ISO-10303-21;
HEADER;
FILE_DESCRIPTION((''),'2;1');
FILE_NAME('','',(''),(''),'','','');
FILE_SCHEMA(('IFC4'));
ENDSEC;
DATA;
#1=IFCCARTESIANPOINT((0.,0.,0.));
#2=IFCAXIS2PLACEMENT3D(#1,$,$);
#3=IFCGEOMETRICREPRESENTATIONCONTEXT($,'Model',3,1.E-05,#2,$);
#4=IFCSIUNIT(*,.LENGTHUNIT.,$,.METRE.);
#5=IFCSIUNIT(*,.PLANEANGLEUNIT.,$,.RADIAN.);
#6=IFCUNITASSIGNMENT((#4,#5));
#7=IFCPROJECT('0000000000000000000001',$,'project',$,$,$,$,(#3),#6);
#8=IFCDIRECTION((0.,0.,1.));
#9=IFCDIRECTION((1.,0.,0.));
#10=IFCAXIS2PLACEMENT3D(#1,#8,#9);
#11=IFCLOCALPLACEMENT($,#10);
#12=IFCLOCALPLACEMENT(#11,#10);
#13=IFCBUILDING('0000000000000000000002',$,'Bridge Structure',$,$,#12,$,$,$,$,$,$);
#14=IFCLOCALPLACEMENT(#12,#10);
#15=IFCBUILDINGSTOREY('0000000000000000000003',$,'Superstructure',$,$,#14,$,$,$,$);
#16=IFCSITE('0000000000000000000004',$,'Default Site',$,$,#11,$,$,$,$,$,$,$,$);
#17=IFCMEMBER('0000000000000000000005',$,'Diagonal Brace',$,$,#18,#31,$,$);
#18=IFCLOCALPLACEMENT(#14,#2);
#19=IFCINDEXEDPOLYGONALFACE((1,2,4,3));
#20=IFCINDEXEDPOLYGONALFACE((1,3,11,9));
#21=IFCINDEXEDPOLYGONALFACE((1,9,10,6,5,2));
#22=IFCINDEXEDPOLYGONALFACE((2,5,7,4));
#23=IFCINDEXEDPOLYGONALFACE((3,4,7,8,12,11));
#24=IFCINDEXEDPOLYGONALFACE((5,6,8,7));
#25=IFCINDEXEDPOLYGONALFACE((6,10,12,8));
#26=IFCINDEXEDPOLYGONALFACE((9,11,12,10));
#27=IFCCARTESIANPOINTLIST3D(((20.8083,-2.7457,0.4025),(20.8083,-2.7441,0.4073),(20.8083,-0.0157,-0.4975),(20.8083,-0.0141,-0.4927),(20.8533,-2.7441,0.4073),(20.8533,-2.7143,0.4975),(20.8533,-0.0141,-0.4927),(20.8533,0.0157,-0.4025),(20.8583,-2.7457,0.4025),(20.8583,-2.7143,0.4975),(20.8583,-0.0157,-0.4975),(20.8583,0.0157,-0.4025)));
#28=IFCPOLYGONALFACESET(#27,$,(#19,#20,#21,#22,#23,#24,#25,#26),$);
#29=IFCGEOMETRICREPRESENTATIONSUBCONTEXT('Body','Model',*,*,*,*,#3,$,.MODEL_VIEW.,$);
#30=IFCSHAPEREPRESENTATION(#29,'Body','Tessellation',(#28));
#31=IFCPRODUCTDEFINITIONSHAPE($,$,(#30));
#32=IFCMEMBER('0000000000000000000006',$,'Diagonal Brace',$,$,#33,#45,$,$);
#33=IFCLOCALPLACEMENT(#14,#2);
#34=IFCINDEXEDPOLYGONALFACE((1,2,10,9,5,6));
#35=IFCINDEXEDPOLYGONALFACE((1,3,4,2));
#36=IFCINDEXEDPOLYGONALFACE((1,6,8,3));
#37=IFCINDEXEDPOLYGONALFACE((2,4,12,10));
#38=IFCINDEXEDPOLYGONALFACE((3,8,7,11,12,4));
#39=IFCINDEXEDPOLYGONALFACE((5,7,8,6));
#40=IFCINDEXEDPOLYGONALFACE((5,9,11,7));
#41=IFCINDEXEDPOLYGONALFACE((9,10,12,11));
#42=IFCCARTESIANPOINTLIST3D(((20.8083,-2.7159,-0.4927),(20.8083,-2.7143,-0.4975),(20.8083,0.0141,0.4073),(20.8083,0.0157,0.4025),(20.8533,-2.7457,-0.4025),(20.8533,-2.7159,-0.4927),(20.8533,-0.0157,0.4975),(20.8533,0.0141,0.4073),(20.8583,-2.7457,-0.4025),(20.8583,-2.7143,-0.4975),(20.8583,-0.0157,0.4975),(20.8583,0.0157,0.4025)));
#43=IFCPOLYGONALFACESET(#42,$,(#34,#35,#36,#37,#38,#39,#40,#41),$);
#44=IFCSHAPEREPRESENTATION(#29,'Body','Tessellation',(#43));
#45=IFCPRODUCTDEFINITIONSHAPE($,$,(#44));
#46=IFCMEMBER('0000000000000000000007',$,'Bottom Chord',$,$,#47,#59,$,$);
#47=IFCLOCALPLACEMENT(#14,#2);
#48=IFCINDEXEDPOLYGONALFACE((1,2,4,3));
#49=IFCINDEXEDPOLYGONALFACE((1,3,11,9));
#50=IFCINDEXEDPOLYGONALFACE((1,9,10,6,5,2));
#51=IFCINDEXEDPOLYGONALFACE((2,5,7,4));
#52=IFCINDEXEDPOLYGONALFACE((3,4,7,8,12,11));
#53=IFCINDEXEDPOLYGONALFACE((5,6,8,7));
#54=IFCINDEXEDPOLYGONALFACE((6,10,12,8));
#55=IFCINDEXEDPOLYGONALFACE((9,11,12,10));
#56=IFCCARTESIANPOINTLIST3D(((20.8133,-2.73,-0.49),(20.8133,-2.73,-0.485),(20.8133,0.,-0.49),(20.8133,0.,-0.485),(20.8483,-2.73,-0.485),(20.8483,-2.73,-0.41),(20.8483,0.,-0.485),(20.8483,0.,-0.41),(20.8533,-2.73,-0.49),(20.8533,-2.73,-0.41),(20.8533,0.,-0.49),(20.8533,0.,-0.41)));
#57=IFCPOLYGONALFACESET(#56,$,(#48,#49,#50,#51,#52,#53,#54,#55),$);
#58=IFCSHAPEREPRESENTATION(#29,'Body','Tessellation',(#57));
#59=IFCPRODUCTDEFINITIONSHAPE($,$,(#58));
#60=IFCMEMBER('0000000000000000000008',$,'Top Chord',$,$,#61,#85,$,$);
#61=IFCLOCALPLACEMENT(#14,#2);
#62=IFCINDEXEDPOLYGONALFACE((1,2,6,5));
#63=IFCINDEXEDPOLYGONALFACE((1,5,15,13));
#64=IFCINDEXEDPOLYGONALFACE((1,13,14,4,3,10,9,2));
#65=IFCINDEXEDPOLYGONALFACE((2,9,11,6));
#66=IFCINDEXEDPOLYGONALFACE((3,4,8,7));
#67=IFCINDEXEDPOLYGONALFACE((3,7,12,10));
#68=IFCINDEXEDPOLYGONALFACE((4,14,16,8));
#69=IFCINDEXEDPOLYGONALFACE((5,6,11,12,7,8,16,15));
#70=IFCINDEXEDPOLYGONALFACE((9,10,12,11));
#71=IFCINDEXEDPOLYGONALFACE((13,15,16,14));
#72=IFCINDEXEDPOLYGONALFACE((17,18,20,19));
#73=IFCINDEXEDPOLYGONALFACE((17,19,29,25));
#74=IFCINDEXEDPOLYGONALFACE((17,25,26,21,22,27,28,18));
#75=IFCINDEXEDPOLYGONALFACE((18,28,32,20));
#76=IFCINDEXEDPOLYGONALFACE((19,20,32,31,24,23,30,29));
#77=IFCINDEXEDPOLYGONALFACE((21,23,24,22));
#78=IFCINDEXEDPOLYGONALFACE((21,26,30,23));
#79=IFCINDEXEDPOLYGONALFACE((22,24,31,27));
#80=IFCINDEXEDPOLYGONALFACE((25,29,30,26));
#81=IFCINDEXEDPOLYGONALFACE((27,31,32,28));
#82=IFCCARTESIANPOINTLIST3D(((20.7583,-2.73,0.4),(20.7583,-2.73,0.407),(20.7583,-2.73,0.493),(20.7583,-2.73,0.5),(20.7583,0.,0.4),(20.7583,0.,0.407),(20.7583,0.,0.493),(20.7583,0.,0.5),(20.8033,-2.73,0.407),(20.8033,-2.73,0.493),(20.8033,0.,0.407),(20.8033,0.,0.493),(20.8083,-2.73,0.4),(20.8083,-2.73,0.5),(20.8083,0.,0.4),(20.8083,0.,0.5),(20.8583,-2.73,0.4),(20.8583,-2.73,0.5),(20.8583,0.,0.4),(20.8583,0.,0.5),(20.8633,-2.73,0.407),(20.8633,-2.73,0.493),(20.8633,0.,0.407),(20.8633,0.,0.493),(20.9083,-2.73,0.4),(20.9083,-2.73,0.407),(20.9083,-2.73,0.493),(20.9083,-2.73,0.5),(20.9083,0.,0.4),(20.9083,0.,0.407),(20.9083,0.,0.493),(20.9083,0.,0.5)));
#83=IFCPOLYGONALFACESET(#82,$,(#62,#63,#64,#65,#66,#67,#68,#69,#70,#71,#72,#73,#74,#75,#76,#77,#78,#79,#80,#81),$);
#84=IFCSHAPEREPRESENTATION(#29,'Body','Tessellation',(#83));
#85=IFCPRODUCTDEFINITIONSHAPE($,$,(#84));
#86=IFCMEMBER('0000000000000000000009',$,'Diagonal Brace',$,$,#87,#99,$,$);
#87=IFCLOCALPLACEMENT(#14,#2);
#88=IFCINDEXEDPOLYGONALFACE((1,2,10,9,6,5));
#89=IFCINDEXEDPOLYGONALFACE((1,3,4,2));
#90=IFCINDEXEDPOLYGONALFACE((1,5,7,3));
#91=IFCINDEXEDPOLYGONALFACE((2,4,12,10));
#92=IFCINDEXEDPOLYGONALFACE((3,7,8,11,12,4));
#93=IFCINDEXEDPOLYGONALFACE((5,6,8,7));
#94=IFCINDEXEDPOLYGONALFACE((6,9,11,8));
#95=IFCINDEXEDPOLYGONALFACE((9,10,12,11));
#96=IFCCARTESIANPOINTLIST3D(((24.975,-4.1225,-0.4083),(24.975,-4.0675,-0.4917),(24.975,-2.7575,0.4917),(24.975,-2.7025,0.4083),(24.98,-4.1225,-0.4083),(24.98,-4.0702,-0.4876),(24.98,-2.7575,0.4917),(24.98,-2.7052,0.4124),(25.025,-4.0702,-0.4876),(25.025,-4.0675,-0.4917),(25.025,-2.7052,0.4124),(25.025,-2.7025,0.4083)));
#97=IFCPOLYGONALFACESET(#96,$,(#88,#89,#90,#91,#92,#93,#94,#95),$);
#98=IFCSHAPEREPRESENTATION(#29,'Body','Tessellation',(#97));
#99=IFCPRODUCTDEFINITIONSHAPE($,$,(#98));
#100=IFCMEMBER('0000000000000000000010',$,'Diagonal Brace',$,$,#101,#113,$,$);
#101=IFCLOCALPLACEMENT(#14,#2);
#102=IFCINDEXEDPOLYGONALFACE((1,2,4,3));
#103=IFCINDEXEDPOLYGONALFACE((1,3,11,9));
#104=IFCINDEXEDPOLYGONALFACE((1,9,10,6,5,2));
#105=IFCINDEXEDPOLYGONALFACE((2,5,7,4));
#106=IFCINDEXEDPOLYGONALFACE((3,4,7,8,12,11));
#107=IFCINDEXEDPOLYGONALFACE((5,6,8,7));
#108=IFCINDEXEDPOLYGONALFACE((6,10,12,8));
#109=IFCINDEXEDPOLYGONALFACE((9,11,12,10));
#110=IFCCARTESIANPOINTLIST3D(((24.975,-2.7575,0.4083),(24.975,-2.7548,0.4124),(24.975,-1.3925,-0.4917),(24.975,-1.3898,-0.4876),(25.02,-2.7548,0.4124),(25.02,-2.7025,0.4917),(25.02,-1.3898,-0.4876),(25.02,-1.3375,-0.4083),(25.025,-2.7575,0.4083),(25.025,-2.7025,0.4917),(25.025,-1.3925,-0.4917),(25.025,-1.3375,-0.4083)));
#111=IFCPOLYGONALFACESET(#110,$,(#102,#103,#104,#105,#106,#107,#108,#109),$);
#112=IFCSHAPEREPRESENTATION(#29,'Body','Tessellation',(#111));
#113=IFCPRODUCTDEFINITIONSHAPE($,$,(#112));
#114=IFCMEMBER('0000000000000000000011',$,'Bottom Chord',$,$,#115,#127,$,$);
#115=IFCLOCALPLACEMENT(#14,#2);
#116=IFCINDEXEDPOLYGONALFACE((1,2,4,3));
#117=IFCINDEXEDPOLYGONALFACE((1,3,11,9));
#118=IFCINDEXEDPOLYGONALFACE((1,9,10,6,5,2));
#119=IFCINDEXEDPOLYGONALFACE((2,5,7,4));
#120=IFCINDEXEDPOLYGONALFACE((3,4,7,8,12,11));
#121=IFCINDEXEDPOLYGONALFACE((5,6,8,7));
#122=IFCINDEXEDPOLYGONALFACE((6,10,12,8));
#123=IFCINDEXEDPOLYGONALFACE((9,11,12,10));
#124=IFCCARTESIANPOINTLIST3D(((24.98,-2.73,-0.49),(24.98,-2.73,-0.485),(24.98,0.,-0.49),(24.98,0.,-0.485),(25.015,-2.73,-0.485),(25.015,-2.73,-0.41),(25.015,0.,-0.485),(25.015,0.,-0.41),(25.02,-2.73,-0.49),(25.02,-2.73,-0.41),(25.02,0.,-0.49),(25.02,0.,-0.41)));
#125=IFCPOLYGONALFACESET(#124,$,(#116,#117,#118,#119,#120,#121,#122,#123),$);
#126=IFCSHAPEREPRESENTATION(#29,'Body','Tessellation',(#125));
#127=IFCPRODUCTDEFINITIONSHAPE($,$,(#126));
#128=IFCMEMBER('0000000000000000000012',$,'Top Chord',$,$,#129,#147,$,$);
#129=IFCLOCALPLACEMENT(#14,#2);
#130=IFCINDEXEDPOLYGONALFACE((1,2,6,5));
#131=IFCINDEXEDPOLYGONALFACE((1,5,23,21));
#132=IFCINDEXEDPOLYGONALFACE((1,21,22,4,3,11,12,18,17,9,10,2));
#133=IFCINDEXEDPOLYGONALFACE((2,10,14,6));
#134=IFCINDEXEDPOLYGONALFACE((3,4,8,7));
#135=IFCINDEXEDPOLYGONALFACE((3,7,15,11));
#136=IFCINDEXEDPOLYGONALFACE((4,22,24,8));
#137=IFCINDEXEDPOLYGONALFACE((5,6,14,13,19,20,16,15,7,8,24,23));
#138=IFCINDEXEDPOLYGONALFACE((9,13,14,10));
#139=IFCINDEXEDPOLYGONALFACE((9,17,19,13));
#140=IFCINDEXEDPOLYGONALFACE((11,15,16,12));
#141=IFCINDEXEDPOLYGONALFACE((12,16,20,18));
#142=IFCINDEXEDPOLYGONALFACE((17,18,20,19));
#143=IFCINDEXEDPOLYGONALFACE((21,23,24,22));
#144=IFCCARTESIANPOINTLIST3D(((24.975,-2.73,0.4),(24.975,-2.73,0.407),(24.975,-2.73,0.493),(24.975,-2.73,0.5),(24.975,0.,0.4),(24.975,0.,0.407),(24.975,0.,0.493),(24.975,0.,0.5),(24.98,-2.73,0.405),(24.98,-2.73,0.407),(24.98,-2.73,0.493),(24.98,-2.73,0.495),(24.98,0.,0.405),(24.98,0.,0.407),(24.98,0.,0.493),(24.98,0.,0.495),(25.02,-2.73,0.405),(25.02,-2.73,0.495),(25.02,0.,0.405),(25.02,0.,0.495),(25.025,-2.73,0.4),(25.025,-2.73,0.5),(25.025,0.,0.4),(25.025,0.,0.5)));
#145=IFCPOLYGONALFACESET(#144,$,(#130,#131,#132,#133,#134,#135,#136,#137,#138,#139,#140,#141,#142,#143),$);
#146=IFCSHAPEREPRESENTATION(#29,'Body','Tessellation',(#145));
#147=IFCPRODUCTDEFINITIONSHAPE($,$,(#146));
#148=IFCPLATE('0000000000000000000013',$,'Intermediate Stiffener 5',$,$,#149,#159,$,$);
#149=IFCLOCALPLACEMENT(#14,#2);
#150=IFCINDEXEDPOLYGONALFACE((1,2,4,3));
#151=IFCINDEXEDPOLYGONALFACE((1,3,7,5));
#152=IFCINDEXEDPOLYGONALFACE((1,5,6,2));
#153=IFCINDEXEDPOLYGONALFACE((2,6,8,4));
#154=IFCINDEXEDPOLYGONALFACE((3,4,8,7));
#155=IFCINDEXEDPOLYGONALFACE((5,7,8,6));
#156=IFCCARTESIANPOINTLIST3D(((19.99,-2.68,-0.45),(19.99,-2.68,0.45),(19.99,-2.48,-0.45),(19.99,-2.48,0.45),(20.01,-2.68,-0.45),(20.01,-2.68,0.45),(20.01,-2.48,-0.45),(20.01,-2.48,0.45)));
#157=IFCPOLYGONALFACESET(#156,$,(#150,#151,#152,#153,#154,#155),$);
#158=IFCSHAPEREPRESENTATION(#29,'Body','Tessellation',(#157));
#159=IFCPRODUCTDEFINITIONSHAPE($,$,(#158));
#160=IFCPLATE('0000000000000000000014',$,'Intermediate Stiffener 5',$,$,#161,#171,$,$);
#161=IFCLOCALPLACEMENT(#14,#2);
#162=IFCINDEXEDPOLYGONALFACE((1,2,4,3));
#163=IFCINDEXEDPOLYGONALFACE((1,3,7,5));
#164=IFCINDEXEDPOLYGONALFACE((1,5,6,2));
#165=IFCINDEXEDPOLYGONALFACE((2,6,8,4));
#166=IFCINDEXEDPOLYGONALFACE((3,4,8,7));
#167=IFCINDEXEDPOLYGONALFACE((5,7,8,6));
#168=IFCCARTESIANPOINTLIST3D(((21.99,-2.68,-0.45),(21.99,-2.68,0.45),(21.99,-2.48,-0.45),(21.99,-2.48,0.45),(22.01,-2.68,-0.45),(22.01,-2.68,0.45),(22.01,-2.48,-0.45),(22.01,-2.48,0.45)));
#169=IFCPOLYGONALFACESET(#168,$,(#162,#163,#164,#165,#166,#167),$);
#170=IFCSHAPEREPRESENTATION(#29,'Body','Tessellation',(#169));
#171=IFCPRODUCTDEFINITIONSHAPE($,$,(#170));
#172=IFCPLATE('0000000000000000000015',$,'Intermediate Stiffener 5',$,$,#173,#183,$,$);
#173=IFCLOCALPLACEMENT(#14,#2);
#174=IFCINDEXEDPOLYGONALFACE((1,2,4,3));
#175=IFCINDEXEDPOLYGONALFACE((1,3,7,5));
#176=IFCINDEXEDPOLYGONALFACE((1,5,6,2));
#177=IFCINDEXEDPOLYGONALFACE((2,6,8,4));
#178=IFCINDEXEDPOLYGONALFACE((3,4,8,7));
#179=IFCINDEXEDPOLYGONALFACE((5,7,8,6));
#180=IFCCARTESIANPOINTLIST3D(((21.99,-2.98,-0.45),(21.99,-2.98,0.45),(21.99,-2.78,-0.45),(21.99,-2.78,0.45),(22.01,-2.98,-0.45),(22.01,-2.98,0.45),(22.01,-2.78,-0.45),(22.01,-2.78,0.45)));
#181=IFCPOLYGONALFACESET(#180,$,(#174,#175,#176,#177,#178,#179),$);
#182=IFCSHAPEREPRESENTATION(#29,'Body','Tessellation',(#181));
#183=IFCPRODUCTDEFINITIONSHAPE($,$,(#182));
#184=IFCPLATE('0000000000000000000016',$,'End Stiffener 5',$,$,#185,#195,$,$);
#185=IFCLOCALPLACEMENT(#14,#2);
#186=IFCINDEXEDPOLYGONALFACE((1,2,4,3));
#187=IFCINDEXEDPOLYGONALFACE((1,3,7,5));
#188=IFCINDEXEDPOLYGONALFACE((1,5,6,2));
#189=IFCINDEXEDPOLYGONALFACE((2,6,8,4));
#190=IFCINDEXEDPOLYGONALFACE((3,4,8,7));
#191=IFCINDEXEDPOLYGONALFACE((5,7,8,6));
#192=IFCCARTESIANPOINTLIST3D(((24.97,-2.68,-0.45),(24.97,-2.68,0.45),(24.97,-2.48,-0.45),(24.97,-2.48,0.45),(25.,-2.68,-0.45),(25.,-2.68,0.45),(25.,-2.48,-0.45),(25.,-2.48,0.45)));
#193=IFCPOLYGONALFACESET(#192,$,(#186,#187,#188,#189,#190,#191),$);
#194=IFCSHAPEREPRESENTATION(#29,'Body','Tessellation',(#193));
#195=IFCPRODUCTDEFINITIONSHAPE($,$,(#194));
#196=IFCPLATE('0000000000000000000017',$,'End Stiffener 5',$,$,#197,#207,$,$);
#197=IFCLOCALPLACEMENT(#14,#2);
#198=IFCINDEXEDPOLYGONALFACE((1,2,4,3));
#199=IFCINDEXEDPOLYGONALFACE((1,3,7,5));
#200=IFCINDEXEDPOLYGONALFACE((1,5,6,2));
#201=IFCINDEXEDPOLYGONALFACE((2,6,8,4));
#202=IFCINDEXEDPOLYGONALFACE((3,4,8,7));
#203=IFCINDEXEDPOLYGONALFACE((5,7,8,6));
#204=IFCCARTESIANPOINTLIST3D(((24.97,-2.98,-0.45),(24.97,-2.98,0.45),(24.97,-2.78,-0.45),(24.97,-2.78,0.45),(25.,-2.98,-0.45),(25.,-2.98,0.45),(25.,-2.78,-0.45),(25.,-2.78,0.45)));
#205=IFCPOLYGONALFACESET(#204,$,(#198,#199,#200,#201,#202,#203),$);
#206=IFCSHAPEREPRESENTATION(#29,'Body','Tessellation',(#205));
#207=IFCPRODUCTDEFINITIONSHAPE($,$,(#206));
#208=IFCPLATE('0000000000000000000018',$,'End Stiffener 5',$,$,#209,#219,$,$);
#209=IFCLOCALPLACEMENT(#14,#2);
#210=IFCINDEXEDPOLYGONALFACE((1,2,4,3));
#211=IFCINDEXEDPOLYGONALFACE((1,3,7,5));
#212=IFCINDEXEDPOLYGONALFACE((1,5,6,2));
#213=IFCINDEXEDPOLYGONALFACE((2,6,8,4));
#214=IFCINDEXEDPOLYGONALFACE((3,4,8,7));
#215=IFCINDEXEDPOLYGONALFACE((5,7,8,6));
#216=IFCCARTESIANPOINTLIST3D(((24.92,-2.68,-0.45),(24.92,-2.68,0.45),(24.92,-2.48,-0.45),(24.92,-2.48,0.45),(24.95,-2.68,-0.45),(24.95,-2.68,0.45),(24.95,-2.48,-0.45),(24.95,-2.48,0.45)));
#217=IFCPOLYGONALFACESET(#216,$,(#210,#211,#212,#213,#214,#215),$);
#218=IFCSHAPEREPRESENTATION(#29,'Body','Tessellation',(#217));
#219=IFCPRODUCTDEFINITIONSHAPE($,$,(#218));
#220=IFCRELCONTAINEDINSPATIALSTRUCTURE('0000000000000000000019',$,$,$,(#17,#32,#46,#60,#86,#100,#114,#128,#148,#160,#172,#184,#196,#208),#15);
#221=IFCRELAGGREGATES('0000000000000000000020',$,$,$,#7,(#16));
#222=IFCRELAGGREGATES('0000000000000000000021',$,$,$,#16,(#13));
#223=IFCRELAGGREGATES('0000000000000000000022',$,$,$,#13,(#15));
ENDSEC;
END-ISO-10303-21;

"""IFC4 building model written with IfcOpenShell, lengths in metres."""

from ifc_helpers import new_model, si_unit, frame, origin, origin_with_axes, origin_2d_with_axis, place, context, subcontext, project, spatial, polyline, rectangle, l_section, c_section, outline, composite_profile, extrude, element, save


model = new_model("IFC4")

# Units and contexts
model_context = context("Model", 3, precision=1e-05, world=origin())
body_context = subcontext(model_context, "Body", "Model", "MODEL_VIEW")
ifc_project = project(units=[si_unit("LENGTHUNIT", "METRE"), si_unit("PLANEANGLEUNIT", "RADIAN")], contexts=[model_context])

# Site, building, storey
site_placement = place(None, origin_with_axes())
site = spatial("IfcSite", under=ifc_project, at=site_placement, Name="Default Site")
building_placement = place(site_placement, origin_with_axes())
building = spatial("IfcBuilding", under=site, at=building_placement, Name="Bridge Structure")
storey_placement = place(building_placement, origin_with_axes())
storey = spatial("IfcBuildingStorey", under=building, at=storey_placement, Name="Superstructure")

# Members
for number, where, z_axis, x_axis, name in (
    (1, (20.8333, -2.73, 0.45), (0.0, 0.949722, -0.313095), (-1.0, 0.0, 0.0), "Diagonal Brace"),
    (2, (20.8333, -2.73, -0.45), (0.0, 0.949722, 0.313095), (-1.0, 0.0, 0.0), "Diagonal Brace"),
):
    element("IfcMember", number, at=place(storey_placement, frame(where, z_axis=z_axis, x_axis=x_axis)), inside=storey, Name=name, context=body_context, shape_type="SweptSolid", body=[
        extrude(l_section(Depth=0.1, Width=0.05, Thickness=0.005, at=origin_2d_with_axis()), origin_with_axes(), (0.0, 0.0, 1.0), 2.8745),
    ])
member_1_placement = place(storey_placement, frame((20.8333, -2.73, -0.45), z_axis=(0.0, 1.0, 0.0), x_axis=(-1.0, 0.0, 0.0)))
element("IfcMember", 3, at=member_1_placement, inside=storey, Name="Bottom Chord", context=body_context, shape_type="SweptSolid", body=[
    extrude(l_section(Depth=0.08, Width=0.04, Thickness=0.005, at=origin_2d_with_axis()), origin_with_axes(), (0.0, 0.0, 1.0), 2.73),
])
member_2_placement = place(storey_placement, frame((20.8333, -2.73, 0.45), z_axis=(0.0, 1.0, 0.0), x_axis=(-1.0, 0.0, 0.0)))
element("IfcMember", 4, at=member_2_placement, inside=storey, Name="Top Chord", context=body_context, shape_type="SweptSolid", body=[
    extrude(composite_profile([outline(polyline([(-0.025, -0.05), (-0.025, 0.05), (-0.075, 0.05), (-0.075, 0.043), (-0.03, 0.043), (-0.03, -0.043), (-0.075, -0.043), (-0.075, -0.05), (-0.025, -0.05)])), outline(polyline([(0.025, -0.05), (0.075, -0.05), (0.075, -0.043), (0.03, -0.043), (0.03, 0.043), (0.075, 0.043), (0.075, 0.05), (0.025, 0.05), (0.025, -0.05)]))]), origin_with_axes(), (0.0, 0.0, 1.0), 2.73),
])
for number, where, z_axis, x_axis, name in (
    (5, (25.0, -2.73, 0.45), (0.0, -0.834862, -0.550459), (1.0, 0.0, 0.0), "Diagonal Brace"),
    (6, (25.0, -2.73, 0.45), (0.0, 0.834862, -0.550459), (-1.0, 0.0, 0.0), "Diagonal Brace"),
):
    element("IfcMember", number, at=place(storey_placement, frame(where, z_axis=z_axis, x_axis=x_axis)), inside=storey, Name=name, context=body_context, shape_type="SweptSolid", body=[
        extrude(l_section(Depth=0.1, Width=0.05, Thickness=0.005, at=origin_2d_with_axis()), origin_with_axes(), (0.0, 0.0, 1.0), 1.635),
    ])
member_3_placement = place(storey_placement, frame((25.0, -2.73, -0.45), z_axis=(0.0, 1.0, 0.0), x_axis=(-1.0, 0.0, 0.0)))
element("IfcMember", 7, at=member_3_placement, inside=storey, Name="Bottom Chord", context=body_context, shape_type="SweptSolid", body=[
    extrude(l_section(Depth=0.08, Width=0.04, Thickness=0.005, at=origin_2d_with_axis()), origin_with_axes(), (0.0, 0.0, 1.0), 2.73),
])
member_4_placement = place(storey_placement, frame((25.0, -2.73, 0.45), z_axis=(0.0, 1.0, 0.0), x_axis=(-1.0, 0.0, 0.0)))
element("IfcMember", 8, at=member_4_placement, inside=storey, Name="Top Chord", context=body_context, shape_type="SweptSolid", body=[
    extrude(c_section(Depth=0.1, Width=0.05, WallThickness=0.005, Girth=0.007, at=origin_2d_with_axis()), origin_with_axes(), (0.0, 0.0, 1.0), 2.73),
])

# Plates
for number, where, z_axis, x_axis, name in (
    (9, (20.0, -2.58, -0.45), (0.0, 0.0, 1.0), (1.0, 0.0, 0.0), "Intermediate Stiffener 5"),
    (10, (22.0, -2.58, -0.45), (0.0, 0.0, 1.0), (1.0, 0.0, 0.0), "Intermediate Stiffener 5"),
    (11, (22.0, -2.88, -0.45), (0.0, 0.0, 1.0), (1.0, 0.0, 0.0), "Intermediate Stiffener 5"),
):
    element("IfcPlate", number, at=place(storey_placement, frame(where, z_axis=z_axis, x_axis=x_axis)), inside=storey, Name=name, context=body_context, shape_type="SweptSolid", body=[
        extrude(rectangle(XDim=0.02, YDim=0.2, at=origin_2d_with_axis()), origin_with_axes(), (0.0, 0.0, 1.0), 0.9),
    ])
for number, where, z_axis, x_axis, name in (
    (12, (24.985, -2.58, -0.45), (0.0, 0.0, 1.0), (1.0, 0.0, 0.0), "End Stiffener 5"),
    (13, (24.985, -2.88, -0.45), (0.0, 0.0, 1.0), (1.0, 0.0, 0.0), "End Stiffener 5"),
    (14, (24.935, -2.58, -0.45), (0.0, 0.0, 1.0), (1.0, 0.0, 0.0), "End Stiffener 5"),
):
    element("IfcPlate", number, at=place(storey_placement, frame(where, z_axis=z_axis, x_axis=x_axis)), inside=storey, Name=name, context=body_context, shape_type="SweptSolid", body=[
        extrude(rectangle(XDim=0.03, YDim=0.2, at=origin_2d_with_axis()), origin_with_axes(), (0.0, 0.0, 1.0), 0.9),
    ])

save(model, "model.ifc")
